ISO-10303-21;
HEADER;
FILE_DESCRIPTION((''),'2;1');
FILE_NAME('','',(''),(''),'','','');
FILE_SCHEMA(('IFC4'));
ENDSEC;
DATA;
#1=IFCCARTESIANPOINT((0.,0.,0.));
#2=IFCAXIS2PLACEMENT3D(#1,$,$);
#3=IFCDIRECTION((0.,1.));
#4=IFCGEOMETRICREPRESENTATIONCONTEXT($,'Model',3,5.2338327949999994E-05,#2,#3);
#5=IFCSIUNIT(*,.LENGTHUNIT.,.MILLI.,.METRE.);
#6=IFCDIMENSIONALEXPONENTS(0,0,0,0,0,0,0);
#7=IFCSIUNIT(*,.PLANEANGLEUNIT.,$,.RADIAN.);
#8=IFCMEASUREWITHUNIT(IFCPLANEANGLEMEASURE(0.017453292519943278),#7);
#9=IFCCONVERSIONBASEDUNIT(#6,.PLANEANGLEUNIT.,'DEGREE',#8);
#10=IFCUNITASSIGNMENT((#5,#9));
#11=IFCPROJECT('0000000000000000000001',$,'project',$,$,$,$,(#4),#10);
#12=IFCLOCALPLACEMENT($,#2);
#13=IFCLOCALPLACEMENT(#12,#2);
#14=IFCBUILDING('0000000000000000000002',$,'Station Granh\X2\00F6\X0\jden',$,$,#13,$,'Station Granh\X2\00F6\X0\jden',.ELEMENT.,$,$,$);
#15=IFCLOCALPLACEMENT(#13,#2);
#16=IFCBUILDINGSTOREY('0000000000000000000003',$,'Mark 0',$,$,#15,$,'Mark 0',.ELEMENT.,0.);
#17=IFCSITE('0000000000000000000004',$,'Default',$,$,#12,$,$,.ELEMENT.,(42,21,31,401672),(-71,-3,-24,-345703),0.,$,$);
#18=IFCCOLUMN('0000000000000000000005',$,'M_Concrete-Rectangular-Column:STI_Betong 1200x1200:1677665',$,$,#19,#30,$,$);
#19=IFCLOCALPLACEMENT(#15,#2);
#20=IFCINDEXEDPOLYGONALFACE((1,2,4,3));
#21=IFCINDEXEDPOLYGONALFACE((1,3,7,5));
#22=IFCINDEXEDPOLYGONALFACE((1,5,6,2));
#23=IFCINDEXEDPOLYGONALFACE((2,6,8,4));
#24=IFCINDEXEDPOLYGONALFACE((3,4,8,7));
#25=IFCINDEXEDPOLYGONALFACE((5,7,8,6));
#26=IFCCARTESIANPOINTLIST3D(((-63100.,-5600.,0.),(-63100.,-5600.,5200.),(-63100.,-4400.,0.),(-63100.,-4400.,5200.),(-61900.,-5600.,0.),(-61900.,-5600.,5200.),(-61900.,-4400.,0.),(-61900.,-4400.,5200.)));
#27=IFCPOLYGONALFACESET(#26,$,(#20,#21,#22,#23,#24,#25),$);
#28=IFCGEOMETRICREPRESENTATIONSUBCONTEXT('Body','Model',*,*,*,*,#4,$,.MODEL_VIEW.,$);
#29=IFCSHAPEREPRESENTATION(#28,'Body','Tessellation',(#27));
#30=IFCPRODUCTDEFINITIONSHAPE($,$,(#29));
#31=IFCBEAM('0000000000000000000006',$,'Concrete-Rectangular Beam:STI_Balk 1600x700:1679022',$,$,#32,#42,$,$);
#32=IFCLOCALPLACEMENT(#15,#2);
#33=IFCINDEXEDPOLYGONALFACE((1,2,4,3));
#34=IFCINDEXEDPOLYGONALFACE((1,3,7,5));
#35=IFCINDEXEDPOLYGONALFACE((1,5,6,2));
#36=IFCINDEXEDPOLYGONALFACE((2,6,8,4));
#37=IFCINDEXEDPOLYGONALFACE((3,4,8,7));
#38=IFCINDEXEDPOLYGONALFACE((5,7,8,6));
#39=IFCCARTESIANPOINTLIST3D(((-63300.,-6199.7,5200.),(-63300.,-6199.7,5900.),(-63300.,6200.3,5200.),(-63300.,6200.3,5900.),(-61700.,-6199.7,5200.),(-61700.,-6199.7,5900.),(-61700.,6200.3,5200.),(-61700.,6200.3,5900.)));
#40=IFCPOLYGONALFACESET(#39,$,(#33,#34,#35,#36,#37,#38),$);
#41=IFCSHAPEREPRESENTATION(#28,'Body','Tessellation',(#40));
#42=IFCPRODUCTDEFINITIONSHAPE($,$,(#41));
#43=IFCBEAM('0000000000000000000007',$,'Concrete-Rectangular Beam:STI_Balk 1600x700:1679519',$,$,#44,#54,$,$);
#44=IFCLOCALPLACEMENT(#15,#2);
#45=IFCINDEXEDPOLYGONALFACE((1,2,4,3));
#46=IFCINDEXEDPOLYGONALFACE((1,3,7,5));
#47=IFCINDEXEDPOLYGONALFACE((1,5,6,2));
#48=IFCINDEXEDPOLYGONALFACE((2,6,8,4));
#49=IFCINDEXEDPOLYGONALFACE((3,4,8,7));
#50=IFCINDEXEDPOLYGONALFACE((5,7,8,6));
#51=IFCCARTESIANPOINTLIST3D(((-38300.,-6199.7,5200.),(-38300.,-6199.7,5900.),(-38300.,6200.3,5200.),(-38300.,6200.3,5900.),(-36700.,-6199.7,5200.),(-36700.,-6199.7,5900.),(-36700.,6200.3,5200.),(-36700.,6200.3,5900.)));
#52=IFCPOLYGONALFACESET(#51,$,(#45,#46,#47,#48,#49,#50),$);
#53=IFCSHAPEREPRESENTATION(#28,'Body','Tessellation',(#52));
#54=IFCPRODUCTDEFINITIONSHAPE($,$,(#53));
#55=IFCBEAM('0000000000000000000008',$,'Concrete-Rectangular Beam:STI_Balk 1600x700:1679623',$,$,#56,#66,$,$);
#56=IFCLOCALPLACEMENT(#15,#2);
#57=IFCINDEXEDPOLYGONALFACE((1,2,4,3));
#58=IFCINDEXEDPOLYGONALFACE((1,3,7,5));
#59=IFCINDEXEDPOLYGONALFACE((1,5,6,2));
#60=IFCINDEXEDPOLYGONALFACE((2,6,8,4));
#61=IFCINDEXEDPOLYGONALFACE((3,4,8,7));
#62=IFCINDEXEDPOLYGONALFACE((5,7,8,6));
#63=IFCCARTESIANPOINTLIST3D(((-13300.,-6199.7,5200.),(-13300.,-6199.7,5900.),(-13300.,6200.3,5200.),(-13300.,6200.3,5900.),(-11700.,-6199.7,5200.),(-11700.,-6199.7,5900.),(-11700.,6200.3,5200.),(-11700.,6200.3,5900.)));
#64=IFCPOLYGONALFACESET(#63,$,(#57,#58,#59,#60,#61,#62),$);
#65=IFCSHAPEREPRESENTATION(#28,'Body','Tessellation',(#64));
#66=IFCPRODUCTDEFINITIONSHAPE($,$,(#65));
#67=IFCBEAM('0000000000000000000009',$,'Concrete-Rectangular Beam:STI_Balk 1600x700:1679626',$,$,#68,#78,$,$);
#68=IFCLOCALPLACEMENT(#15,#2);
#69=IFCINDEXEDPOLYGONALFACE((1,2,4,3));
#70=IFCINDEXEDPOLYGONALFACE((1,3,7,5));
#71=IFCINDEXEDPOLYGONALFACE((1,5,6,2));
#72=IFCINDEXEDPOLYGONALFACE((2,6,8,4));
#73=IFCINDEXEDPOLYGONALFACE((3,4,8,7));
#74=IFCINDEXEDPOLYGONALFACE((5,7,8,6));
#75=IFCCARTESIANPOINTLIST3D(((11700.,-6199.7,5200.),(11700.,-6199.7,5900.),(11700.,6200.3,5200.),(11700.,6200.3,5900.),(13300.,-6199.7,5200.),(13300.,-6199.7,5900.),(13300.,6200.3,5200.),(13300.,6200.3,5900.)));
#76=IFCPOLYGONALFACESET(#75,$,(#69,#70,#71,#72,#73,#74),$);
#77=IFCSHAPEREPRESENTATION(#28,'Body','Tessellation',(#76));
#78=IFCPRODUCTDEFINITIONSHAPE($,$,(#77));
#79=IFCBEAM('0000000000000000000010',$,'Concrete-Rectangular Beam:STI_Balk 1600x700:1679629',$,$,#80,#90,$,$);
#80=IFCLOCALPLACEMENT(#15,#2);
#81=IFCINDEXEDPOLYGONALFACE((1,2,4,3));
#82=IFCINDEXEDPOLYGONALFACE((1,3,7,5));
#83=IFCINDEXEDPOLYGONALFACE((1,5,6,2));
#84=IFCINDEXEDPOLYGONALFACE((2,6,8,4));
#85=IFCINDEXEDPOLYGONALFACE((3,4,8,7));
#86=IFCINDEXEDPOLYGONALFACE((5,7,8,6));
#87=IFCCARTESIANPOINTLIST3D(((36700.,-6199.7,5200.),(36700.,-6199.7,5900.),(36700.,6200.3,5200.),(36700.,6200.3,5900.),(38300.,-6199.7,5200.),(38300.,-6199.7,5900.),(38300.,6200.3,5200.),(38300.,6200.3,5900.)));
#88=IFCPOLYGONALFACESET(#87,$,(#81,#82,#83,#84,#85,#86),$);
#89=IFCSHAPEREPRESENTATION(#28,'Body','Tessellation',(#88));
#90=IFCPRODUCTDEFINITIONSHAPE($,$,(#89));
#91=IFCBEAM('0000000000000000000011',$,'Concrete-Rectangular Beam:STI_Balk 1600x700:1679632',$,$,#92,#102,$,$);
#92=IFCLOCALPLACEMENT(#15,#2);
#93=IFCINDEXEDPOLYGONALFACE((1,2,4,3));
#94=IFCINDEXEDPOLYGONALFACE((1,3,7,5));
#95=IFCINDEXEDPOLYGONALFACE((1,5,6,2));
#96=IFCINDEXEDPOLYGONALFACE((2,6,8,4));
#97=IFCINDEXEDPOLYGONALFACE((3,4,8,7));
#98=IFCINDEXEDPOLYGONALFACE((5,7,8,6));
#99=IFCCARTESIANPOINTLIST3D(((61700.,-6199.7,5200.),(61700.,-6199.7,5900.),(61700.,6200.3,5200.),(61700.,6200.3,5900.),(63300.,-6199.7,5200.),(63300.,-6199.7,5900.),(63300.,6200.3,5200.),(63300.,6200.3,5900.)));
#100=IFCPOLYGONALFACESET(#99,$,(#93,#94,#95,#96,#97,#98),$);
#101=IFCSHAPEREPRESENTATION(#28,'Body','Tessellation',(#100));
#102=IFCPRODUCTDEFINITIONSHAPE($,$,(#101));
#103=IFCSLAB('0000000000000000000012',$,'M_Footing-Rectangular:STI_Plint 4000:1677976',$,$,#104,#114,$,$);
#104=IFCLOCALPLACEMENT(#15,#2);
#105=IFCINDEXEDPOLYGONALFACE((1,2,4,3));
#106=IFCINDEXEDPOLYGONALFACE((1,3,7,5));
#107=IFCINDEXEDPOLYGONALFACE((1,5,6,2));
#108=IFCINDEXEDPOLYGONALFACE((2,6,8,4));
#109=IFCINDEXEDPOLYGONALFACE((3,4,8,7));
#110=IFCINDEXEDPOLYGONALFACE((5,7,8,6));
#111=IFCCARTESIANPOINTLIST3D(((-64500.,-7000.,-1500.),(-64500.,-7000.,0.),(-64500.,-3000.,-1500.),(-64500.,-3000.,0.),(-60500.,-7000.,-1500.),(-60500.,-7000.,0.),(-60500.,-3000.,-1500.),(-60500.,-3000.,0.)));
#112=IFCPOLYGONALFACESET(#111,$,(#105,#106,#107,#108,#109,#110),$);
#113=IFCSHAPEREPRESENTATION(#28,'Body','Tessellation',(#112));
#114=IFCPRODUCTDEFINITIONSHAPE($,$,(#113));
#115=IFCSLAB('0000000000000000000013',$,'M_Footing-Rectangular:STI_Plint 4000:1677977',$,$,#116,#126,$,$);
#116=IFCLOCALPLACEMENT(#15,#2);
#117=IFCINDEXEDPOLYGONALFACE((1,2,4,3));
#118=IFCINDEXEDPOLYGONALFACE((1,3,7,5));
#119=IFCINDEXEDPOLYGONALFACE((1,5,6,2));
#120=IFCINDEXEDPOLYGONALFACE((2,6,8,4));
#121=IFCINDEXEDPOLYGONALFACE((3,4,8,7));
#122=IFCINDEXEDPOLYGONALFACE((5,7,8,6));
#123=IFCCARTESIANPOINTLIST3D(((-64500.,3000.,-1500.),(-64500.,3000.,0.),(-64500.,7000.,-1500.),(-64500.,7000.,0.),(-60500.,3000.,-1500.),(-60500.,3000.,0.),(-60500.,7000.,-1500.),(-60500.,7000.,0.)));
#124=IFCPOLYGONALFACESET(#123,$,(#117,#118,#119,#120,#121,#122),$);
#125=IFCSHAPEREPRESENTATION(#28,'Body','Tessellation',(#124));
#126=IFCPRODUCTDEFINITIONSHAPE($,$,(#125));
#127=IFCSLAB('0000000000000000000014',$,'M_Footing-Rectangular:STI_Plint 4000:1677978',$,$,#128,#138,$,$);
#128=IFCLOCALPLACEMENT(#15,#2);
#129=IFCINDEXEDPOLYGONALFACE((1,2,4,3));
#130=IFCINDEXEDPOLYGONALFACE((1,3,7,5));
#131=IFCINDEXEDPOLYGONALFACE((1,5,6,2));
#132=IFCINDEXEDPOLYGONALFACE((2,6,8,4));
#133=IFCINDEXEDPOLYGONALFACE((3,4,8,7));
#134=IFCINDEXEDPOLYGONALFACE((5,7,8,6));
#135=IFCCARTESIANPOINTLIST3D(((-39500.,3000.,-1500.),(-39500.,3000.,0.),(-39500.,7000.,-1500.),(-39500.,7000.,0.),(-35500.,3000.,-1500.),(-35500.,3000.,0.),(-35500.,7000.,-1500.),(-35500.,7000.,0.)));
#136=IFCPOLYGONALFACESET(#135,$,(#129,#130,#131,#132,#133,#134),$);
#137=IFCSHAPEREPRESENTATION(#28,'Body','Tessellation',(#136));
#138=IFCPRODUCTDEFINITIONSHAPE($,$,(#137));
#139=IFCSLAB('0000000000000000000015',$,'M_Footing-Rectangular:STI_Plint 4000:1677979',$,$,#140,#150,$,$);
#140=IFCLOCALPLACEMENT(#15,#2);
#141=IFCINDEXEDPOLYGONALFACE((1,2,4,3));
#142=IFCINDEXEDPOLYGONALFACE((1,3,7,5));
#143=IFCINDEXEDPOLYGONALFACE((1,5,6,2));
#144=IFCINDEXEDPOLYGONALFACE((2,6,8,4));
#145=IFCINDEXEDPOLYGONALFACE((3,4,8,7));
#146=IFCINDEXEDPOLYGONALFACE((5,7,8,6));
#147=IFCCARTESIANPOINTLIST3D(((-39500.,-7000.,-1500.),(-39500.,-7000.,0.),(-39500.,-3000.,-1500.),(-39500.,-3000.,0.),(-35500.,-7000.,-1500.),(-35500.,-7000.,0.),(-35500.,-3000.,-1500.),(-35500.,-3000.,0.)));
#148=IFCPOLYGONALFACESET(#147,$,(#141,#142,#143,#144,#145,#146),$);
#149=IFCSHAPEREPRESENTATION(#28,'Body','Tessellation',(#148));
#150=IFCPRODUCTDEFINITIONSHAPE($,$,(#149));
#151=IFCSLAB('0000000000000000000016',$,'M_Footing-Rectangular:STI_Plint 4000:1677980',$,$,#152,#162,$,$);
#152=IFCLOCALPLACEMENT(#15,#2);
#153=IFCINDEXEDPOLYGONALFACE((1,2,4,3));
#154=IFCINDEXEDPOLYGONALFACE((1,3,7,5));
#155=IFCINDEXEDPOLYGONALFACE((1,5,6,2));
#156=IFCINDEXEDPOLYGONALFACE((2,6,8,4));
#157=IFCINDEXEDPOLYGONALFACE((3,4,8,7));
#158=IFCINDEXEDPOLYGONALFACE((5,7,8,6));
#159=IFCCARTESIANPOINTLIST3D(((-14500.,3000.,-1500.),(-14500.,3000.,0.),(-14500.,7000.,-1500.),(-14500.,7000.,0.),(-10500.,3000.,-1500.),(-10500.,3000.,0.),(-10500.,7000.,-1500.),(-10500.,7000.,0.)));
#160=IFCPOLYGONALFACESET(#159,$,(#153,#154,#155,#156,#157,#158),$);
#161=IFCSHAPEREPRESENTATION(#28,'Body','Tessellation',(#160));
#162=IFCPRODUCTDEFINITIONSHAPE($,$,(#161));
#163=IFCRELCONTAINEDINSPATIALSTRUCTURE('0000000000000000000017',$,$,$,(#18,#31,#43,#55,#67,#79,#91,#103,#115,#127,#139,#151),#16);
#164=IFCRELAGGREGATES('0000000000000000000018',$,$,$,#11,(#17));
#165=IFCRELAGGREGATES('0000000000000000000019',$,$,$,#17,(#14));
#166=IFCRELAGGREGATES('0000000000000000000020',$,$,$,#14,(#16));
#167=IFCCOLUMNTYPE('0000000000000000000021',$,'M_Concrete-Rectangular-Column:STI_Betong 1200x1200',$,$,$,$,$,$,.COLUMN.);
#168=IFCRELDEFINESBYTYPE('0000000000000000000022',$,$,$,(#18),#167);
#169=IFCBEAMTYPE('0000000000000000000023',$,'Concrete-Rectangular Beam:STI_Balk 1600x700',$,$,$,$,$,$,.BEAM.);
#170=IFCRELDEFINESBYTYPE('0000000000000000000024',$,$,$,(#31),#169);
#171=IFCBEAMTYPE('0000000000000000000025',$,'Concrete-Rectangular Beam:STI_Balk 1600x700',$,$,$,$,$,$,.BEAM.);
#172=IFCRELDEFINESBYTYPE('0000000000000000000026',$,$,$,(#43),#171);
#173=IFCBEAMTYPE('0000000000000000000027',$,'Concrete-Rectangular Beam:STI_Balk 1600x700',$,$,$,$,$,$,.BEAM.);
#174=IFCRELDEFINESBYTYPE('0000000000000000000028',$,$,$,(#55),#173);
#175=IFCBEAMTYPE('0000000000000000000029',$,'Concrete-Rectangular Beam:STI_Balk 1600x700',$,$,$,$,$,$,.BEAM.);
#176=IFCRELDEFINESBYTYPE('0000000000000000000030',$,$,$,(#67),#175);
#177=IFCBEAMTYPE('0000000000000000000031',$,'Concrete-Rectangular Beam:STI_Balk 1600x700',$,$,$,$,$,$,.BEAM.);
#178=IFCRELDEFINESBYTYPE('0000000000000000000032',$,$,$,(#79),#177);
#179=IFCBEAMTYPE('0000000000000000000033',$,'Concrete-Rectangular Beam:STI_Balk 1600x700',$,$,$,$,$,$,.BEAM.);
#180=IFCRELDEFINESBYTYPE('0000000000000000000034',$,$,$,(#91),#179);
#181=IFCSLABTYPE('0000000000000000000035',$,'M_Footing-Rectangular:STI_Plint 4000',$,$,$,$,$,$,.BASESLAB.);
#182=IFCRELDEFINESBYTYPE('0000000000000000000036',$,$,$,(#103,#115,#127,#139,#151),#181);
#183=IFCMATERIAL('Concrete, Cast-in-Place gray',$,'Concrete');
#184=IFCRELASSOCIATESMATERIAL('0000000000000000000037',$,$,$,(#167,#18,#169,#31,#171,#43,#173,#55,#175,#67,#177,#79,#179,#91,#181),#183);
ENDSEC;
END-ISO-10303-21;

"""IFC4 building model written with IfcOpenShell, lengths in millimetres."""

from ifc_helpers import new_model, entity, si_unit, converted_unit, direction, frame, origin, place, context, subcontext, project, spatial, indexed_curve, outline, extrude, source, transform, mapped, material, type_object, type_shapes, element, save


model = new_model("IFC4")

# Units and contexts
model_context = context("Model", 3, precision=5.2338327949999994e-05, world=origin(), true_north=direction((0.0, 1.0)))
body_context = subcontext(model_context, "Body", "Model", "MODEL_VIEW")
ifc_project = project(units=[si_unit("LENGTHUNIT", "METRE", prefix="MILLI"), converted_unit("PLANEANGLEUNIT", "DEGREE", entity("IfcPlaneAngleMeasure", 0.017453292519943278), si_unit("PLANEANGLEUNIT", "RADIAN"), dimensions=[0, 0, 0, 0, 0, 0, 0])], contexts=[model_context])

# Site, building, storey
site_placement = place(None, origin())
site = spatial("IfcSite", under=ifc_project, at=site_placement, Name="Default", CompositionType="ELEMENT", RefLatitude=(42, 21, 31, 401672), RefLongitude=(-71, -3, -24, -345703), RefElevation=0.0)
building_placement = place(site_placement, origin())
building = spatial("IfcBuilding", under=site, at=building_placement, Name="Station Granhöjden", LongName="Station Granhöjden", CompositionType="ELEMENT")
storey_placement = place(building_placement, origin())
storey = spatial("IfcBuildingStorey", under=building, at=storey_placement, Name="Mark 0", LongName="Mark 0", CompositionType="ELEMENT", Elevation=0.0)

# Column
ifc_material = material(Name="Concrete, Cast-in-Place gray", Category="Concrete")
column_type_1 = type_object("IfcColumnType", Name="M_Concrete-Rectangular-Column:STI_Betong 1200x1200", PredefinedType="COLUMN", material=ifc_material)
shared_shape_1 = source(origin(), body_context, "Body", "SweptSolid", [
    extrude(outline(indexed_curve([(-600.0, -600.0), (600.0, -600.0), (600.0, 600.0), (-600.0, 600.0), (-600.0, -600.0)], self_intersect=False)), frame((-62500.0, -5000.0, 0.0), z_axis=(0.0, 0.0, 1.0), x_axis=(-1.0, 0.0, 0.0)), (0.0, 0.0, 1.0), 5200.0),
])
type_shapes(column_type_1, [shared_shape_1])
column_1_placement = place(storey_placement, origin())
element("IfcColumn", 1, at=column_1_placement, inside=storey, type_object=column_type_1, material=ifc_material, Name="M_Concrete-Rectangular-Column:STI_Betong 1200x1200:1677665", context=body_context, shape_type="MappedRepresentation", body=[
    mapped(shared_shape_1, transform((0.0, 0.0, 0.0), scale=1.0)),
])

# Beams
beam_type_1 = type_object("IfcBeamType", Name="Concrete-Rectangular Beam:STI_Balk 1600x700", PredefinedType="BEAM", material=ifc_material)
shared_shape_2 = source(origin(), body_context, "Body", "SweptSolid", [
    extrude(outline(indexed_curve([(-800.0, -350.0), (800.0, -350.0), (800.0, 350.0), (-800.0, 350.0), (-800.0, -350.0)], self_intersect=False)), frame((-62500.0, -6199.7, 5550.0), z_axis=(0.0, 1.0, 0.0), x_axis=(-1.0, 0.0, 0.0)), (0.0, 0.0, 1.0), 12400.0),
])
type_shapes(beam_type_1, [shared_shape_2])
beam_1_placement = place(storey_placement, origin())
element("IfcBeam", 2, at=beam_1_placement, inside=storey, type_object=beam_type_1, material=ifc_material, Name="Concrete-Rectangular Beam:STI_Balk 1600x700:1679022", context=body_context, shape_type="MappedRepresentation", body=[
    mapped(shared_shape_2, transform((0.0, 0.0, 0.0), scale=1.0)),
])
beam_type_2 = type_object("IfcBeamType", Name="Concrete-Rectangular Beam:STI_Balk 1600x700", PredefinedType="BEAM", material=ifc_material)
shared_shape_3 = source(origin(), body_context, "Body", "SweptSolid", [
    extrude(outline(indexed_curve([(-800.0, -350.0), (800.0, -350.0), (800.0, 350.0), (-800.0, 350.0), (-800.0, -350.0)], self_intersect=False)), frame((-37500.0, -6199.7, 5550.0), z_axis=(0.0, 1.0, 0.0), x_axis=(-1.0, 0.0, 0.0)), (0.0, 0.0, 1.0), 12400.0),
])
type_shapes(beam_type_2, [shared_shape_3])
beam_2_placement = place(storey_placement, origin())
element("IfcBeam", 3, at=beam_2_placement, inside=storey, type_object=beam_type_2, material=ifc_material, Name="Concrete-Rectangular Beam:STI_Balk 1600x700:1679519", context=body_context, shape_type="MappedRepresentation", body=[
    mapped(shared_shape_3, transform((0.0, 0.0, 0.0), scale=1.0)),
])
beam_type_3 = type_object("IfcBeamType", Name="Concrete-Rectangular Beam:STI_Balk 1600x700", PredefinedType="BEAM", material=ifc_material)
shared_shape_4 = source(origin(), body_context, "Body", "SweptSolid", [
    extrude(outline(indexed_curve([(-800.0, -350.0), (800.0, -350.0), (800.0, 350.0), (-800.0, 350.0), (-800.0, -350.0)], self_intersect=False)), frame((-12500.0, -6199.7, 5550.0), z_axis=(0.0, 1.0, 0.0), x_axis=(-1.0, 0.0, 0.0)), (0.0, 0.0, 1.0), 12400.0),
])
type_shapes(beam_type_3, [shared_shape_4])
beam_3_placement = place(storey_placement, origin())
element("IfcBeam", 4, at=beam_3_placement, inside=storey, type_object=beam_type_3, material=ifc_material, Name="Concrete-Rectangular Beam:STI_Balk 1600x700:1679623", context=body_context, shape_type="MappedRepresentation", body=[
    mapped(shared_shape_4, transform((0.0, 0.0, 0.0), scale=1.0)),
])
beam_type_4 = type_object("IfcBeamType", Name="Concrete-Rectangular Beam:STI_Balk 1600x700", PredefinedType="BEAM", material=ifc_material)
shared_shape_5 = source(origin(), body_context, "Body", "SweptSolid", [
    extrude(outline(indexed_curve([(-800.0, -350.0), (800.0, -350.0), (800.0, 350.0), (-800.0, 350.0), (-800.0, -350.0)], self_intersect=False)), frame((12500.0, -6199.7, 5550.0), z_axis=(0.0, 1.0, 0.0), x_axis=(-1.0, 0.0, 0.0)), (0.0, 0.0, 1.0), 12400.0),
])
type_shapes(beam_type_4, [shared_shape_5])
beam_4_placement = place(storey_placement, origin())
element("IfcBeam", 5, at=beam_4_placement, inside=storey, type_object=beam_type_4, material=ifc_material, Name="Concrete-Rectangular Beam:STI_Balk 1600x700:1679626", context=body_context, shape_type="MappedRepresentation", body=[
    mapped(shared_shape_5, transform((0.0, 0.0, 0.0), scale=1.0)),
])
beam_type_5 = type_object("IfcBeamType", Name="Concrete-Rectangular Beam:STI_Balk 1600x700", PredefinedType="BEAM", material=ifc_material)
shared_shape_6 = source(origin(), body_context, "Body", "SweptSolid", [
    extrude(outline(indexed_curve([(-800.0, -350.0), (800.0, -350.0), (800.0, 350.0), (-800.0, 350.0), (-800.0, -350.0)], self_intersect=False)), frame((37500.0, -6199.7, 5550.0), z_axis=(0.0, 1.0, 0.0), x_axis=(-1.0, 0.0, 0.0)), (0.0, 0.0, 1.0), 12400.0),
])
type_shapes(beam_type_5, [shared_shape_6])
beam_5_placement = place(storey_placement, origin())
element("IfcBeam", 6, at=beam_5_placement, inside=storey, type_object=beam_type_5, material=ifc_material, Name="Concrete-Rectangular Beam:STI_Balk 1600x700:1679629", context=body_context, shape_type="MappedRepresentation", body=[
    mapped(shared_shape_6, transform((0.0, 0.0, 0.0), scale=1.0)),
])
beam_type_6 = type_object("IfcBeamType", Name="Concrete-Rectangular Beam:STI_Balk 1600x700", PredefinedType="BEAM", material=ifc_material)
shared_shape_7 = source(origin(), body_context, "Body", "SweptSolid", [
    extrude(outline(indexed_curve([(-800.0, -350.0), (800.0, -350.0), (800.0, 350.0), (-800.0, 350.0), (-800.0, -350.0)], self_intersect=False)), frame((62500.0, -6199.7, 5550.0), z_axis=(0.0, 1.0, 0.0), x_axis=(-1.0, 0.0, 0.0)), (0.0, 0.0, 1.0), 12400.0),
])
type_shapes(beam_type_6, [shared_shape_7])
beam_6_placement = place(storey_placement, origin())
element("IfcBeam", 7, at=beam_6_placement, inside=storey, type_object=beam_type_6, material=ifc_material, Name="Concrete-Rectangular Beam:STI_Balk 1600x700:1679632", context=body_context, shape_type="MappedRepresentation", body=[
    mapped(shared_shape_7, transform((0.0, 0.0, 0.0), scale=1.0)),
])

# Slabs
slab_type = type_object("IfcSlabType", Name="M_Footing-Rectangular:STI_Plint 4000", PredefinedType="BASESLAB", material=ifc_material)
slab_1_placement = place(storey_placement, origin())
element("IfcSlab", 8, at=slab_1_placement, inside=storey, type_object=slab_type, Name="M_Footing-Rectangular:STI_Plint 4000:1677976", context=body_context, shape_type="SweptSolid", body=[
    extrude(outline(indexed_curve([(-2000.0, -2000.0), (2000.0, -2000.0), (2000.0, 2000.0), (-2000.0, 2000.0), (-2000.0, -2000.0)], self_intersect=False)), frame((-62500.0, -5000.0, -1500.0), z_axis=(0.0, 0.0, 1.0), x_axis=(-1.0, 0.0, 0.0)), (0.0, 0.0, 1.0), 1500.0),
])
slab_2_placement = place(storey_placement, origin())
element("IfcSlab", 9, at=slab_2_placement, inside=storey, type_object=slab_type, Name="M_Footing-Rectangular:STI_Plint 4000:1677977", context=body_context, shape_type="SweptSolid", body=[
    extrude(outline(indexed_curve([(-2000.0, -2000.0), (2000.0, -2000.0), (2000.0, 2000.0), (-2000.0, 2000.0), (-2000.0, -2000.0)], self_intersect=False)), frame((-62500.0, 5000.0, -1500.0), z_axis=(0.0, 0.0, 1.0), x_axis=(-1.0, 0.0, 0.0)), (0.0, 0.0, 1.0), 1500.0),
])
slab_3_placement = place(storey_placement, origin())
element("IfcSlab", 10, at=slab_3_placement, inside=storey, type_object=slab_type, Name="M_Footing-Rectangular:STI_Plint 4000:1677978", context=body_context, shape_type="SweptSolid", body=[
    extrude(outline(indexed_curve([(-2000.0, -2000.0), (2000.0, -2000.0), (2000.0, 2000.0), (-2000.0, 2000.0), (-2000.0, -2000.0)], self_intersect=False)), frame((-37500.0, 5000.0, -1500.0), z_axis=(0.0, 0.0, 1.0), x_axis=(-1.0, 0.0, 0.0)), (0.0, 0.0, 1.0), 1500.0),
])
slab_4_placement = place(storey_placement, origin())
element("IfcSlab", 11, at=slab_4_placement, inside=storey, type_object=slab_type, Name="M_Footing-Rectangular:STI_Plint 4000:1677979", context=body_context, shape_type="SweptSolid", body=[
    extrude(outline(indexed_curve([(-2000.0, -2000.0), (2000.0, -2000.0), (2000.0, 2000.0), (-2000.0, 2000.0), (-2000.0, -2000.0)], self_intersect=False)), frame((-37500.0, -5000.0, -1500.0), z_axis=(0.0, 0.0, 1.0), x_axis=(-1.0, 0.0, 0.0)), (0.0, 0.0, 1.0), 1500.0),
])
slab_5_placement = place(storey_placement, origin())
element("IfcSlab", 12, at=slab_5_placement, inside=storey, type_object=slab_type, Name="M_Footing-Rectangular:STI_Plint 4000:1677980", context=body_context, shape_type="SweptSolid", body=[
    extrude(outline(indexed_curve([(-2000.0, -2000.0), (2000.0, -2000.0), (2000.0, 2000.0), (-2000.0, 2000.0), (-2000.0, -2000.0)], self_intersect=False)), frame((-12500.0, 5000.0, -1500.0), z_axis=(0.0, 0.0, 1.0), x_axis=(-1.0, 0.0, 0.0)), (0.0, 0.0, 1.0), 1500.0),
])

save(model, "model.ifc")
